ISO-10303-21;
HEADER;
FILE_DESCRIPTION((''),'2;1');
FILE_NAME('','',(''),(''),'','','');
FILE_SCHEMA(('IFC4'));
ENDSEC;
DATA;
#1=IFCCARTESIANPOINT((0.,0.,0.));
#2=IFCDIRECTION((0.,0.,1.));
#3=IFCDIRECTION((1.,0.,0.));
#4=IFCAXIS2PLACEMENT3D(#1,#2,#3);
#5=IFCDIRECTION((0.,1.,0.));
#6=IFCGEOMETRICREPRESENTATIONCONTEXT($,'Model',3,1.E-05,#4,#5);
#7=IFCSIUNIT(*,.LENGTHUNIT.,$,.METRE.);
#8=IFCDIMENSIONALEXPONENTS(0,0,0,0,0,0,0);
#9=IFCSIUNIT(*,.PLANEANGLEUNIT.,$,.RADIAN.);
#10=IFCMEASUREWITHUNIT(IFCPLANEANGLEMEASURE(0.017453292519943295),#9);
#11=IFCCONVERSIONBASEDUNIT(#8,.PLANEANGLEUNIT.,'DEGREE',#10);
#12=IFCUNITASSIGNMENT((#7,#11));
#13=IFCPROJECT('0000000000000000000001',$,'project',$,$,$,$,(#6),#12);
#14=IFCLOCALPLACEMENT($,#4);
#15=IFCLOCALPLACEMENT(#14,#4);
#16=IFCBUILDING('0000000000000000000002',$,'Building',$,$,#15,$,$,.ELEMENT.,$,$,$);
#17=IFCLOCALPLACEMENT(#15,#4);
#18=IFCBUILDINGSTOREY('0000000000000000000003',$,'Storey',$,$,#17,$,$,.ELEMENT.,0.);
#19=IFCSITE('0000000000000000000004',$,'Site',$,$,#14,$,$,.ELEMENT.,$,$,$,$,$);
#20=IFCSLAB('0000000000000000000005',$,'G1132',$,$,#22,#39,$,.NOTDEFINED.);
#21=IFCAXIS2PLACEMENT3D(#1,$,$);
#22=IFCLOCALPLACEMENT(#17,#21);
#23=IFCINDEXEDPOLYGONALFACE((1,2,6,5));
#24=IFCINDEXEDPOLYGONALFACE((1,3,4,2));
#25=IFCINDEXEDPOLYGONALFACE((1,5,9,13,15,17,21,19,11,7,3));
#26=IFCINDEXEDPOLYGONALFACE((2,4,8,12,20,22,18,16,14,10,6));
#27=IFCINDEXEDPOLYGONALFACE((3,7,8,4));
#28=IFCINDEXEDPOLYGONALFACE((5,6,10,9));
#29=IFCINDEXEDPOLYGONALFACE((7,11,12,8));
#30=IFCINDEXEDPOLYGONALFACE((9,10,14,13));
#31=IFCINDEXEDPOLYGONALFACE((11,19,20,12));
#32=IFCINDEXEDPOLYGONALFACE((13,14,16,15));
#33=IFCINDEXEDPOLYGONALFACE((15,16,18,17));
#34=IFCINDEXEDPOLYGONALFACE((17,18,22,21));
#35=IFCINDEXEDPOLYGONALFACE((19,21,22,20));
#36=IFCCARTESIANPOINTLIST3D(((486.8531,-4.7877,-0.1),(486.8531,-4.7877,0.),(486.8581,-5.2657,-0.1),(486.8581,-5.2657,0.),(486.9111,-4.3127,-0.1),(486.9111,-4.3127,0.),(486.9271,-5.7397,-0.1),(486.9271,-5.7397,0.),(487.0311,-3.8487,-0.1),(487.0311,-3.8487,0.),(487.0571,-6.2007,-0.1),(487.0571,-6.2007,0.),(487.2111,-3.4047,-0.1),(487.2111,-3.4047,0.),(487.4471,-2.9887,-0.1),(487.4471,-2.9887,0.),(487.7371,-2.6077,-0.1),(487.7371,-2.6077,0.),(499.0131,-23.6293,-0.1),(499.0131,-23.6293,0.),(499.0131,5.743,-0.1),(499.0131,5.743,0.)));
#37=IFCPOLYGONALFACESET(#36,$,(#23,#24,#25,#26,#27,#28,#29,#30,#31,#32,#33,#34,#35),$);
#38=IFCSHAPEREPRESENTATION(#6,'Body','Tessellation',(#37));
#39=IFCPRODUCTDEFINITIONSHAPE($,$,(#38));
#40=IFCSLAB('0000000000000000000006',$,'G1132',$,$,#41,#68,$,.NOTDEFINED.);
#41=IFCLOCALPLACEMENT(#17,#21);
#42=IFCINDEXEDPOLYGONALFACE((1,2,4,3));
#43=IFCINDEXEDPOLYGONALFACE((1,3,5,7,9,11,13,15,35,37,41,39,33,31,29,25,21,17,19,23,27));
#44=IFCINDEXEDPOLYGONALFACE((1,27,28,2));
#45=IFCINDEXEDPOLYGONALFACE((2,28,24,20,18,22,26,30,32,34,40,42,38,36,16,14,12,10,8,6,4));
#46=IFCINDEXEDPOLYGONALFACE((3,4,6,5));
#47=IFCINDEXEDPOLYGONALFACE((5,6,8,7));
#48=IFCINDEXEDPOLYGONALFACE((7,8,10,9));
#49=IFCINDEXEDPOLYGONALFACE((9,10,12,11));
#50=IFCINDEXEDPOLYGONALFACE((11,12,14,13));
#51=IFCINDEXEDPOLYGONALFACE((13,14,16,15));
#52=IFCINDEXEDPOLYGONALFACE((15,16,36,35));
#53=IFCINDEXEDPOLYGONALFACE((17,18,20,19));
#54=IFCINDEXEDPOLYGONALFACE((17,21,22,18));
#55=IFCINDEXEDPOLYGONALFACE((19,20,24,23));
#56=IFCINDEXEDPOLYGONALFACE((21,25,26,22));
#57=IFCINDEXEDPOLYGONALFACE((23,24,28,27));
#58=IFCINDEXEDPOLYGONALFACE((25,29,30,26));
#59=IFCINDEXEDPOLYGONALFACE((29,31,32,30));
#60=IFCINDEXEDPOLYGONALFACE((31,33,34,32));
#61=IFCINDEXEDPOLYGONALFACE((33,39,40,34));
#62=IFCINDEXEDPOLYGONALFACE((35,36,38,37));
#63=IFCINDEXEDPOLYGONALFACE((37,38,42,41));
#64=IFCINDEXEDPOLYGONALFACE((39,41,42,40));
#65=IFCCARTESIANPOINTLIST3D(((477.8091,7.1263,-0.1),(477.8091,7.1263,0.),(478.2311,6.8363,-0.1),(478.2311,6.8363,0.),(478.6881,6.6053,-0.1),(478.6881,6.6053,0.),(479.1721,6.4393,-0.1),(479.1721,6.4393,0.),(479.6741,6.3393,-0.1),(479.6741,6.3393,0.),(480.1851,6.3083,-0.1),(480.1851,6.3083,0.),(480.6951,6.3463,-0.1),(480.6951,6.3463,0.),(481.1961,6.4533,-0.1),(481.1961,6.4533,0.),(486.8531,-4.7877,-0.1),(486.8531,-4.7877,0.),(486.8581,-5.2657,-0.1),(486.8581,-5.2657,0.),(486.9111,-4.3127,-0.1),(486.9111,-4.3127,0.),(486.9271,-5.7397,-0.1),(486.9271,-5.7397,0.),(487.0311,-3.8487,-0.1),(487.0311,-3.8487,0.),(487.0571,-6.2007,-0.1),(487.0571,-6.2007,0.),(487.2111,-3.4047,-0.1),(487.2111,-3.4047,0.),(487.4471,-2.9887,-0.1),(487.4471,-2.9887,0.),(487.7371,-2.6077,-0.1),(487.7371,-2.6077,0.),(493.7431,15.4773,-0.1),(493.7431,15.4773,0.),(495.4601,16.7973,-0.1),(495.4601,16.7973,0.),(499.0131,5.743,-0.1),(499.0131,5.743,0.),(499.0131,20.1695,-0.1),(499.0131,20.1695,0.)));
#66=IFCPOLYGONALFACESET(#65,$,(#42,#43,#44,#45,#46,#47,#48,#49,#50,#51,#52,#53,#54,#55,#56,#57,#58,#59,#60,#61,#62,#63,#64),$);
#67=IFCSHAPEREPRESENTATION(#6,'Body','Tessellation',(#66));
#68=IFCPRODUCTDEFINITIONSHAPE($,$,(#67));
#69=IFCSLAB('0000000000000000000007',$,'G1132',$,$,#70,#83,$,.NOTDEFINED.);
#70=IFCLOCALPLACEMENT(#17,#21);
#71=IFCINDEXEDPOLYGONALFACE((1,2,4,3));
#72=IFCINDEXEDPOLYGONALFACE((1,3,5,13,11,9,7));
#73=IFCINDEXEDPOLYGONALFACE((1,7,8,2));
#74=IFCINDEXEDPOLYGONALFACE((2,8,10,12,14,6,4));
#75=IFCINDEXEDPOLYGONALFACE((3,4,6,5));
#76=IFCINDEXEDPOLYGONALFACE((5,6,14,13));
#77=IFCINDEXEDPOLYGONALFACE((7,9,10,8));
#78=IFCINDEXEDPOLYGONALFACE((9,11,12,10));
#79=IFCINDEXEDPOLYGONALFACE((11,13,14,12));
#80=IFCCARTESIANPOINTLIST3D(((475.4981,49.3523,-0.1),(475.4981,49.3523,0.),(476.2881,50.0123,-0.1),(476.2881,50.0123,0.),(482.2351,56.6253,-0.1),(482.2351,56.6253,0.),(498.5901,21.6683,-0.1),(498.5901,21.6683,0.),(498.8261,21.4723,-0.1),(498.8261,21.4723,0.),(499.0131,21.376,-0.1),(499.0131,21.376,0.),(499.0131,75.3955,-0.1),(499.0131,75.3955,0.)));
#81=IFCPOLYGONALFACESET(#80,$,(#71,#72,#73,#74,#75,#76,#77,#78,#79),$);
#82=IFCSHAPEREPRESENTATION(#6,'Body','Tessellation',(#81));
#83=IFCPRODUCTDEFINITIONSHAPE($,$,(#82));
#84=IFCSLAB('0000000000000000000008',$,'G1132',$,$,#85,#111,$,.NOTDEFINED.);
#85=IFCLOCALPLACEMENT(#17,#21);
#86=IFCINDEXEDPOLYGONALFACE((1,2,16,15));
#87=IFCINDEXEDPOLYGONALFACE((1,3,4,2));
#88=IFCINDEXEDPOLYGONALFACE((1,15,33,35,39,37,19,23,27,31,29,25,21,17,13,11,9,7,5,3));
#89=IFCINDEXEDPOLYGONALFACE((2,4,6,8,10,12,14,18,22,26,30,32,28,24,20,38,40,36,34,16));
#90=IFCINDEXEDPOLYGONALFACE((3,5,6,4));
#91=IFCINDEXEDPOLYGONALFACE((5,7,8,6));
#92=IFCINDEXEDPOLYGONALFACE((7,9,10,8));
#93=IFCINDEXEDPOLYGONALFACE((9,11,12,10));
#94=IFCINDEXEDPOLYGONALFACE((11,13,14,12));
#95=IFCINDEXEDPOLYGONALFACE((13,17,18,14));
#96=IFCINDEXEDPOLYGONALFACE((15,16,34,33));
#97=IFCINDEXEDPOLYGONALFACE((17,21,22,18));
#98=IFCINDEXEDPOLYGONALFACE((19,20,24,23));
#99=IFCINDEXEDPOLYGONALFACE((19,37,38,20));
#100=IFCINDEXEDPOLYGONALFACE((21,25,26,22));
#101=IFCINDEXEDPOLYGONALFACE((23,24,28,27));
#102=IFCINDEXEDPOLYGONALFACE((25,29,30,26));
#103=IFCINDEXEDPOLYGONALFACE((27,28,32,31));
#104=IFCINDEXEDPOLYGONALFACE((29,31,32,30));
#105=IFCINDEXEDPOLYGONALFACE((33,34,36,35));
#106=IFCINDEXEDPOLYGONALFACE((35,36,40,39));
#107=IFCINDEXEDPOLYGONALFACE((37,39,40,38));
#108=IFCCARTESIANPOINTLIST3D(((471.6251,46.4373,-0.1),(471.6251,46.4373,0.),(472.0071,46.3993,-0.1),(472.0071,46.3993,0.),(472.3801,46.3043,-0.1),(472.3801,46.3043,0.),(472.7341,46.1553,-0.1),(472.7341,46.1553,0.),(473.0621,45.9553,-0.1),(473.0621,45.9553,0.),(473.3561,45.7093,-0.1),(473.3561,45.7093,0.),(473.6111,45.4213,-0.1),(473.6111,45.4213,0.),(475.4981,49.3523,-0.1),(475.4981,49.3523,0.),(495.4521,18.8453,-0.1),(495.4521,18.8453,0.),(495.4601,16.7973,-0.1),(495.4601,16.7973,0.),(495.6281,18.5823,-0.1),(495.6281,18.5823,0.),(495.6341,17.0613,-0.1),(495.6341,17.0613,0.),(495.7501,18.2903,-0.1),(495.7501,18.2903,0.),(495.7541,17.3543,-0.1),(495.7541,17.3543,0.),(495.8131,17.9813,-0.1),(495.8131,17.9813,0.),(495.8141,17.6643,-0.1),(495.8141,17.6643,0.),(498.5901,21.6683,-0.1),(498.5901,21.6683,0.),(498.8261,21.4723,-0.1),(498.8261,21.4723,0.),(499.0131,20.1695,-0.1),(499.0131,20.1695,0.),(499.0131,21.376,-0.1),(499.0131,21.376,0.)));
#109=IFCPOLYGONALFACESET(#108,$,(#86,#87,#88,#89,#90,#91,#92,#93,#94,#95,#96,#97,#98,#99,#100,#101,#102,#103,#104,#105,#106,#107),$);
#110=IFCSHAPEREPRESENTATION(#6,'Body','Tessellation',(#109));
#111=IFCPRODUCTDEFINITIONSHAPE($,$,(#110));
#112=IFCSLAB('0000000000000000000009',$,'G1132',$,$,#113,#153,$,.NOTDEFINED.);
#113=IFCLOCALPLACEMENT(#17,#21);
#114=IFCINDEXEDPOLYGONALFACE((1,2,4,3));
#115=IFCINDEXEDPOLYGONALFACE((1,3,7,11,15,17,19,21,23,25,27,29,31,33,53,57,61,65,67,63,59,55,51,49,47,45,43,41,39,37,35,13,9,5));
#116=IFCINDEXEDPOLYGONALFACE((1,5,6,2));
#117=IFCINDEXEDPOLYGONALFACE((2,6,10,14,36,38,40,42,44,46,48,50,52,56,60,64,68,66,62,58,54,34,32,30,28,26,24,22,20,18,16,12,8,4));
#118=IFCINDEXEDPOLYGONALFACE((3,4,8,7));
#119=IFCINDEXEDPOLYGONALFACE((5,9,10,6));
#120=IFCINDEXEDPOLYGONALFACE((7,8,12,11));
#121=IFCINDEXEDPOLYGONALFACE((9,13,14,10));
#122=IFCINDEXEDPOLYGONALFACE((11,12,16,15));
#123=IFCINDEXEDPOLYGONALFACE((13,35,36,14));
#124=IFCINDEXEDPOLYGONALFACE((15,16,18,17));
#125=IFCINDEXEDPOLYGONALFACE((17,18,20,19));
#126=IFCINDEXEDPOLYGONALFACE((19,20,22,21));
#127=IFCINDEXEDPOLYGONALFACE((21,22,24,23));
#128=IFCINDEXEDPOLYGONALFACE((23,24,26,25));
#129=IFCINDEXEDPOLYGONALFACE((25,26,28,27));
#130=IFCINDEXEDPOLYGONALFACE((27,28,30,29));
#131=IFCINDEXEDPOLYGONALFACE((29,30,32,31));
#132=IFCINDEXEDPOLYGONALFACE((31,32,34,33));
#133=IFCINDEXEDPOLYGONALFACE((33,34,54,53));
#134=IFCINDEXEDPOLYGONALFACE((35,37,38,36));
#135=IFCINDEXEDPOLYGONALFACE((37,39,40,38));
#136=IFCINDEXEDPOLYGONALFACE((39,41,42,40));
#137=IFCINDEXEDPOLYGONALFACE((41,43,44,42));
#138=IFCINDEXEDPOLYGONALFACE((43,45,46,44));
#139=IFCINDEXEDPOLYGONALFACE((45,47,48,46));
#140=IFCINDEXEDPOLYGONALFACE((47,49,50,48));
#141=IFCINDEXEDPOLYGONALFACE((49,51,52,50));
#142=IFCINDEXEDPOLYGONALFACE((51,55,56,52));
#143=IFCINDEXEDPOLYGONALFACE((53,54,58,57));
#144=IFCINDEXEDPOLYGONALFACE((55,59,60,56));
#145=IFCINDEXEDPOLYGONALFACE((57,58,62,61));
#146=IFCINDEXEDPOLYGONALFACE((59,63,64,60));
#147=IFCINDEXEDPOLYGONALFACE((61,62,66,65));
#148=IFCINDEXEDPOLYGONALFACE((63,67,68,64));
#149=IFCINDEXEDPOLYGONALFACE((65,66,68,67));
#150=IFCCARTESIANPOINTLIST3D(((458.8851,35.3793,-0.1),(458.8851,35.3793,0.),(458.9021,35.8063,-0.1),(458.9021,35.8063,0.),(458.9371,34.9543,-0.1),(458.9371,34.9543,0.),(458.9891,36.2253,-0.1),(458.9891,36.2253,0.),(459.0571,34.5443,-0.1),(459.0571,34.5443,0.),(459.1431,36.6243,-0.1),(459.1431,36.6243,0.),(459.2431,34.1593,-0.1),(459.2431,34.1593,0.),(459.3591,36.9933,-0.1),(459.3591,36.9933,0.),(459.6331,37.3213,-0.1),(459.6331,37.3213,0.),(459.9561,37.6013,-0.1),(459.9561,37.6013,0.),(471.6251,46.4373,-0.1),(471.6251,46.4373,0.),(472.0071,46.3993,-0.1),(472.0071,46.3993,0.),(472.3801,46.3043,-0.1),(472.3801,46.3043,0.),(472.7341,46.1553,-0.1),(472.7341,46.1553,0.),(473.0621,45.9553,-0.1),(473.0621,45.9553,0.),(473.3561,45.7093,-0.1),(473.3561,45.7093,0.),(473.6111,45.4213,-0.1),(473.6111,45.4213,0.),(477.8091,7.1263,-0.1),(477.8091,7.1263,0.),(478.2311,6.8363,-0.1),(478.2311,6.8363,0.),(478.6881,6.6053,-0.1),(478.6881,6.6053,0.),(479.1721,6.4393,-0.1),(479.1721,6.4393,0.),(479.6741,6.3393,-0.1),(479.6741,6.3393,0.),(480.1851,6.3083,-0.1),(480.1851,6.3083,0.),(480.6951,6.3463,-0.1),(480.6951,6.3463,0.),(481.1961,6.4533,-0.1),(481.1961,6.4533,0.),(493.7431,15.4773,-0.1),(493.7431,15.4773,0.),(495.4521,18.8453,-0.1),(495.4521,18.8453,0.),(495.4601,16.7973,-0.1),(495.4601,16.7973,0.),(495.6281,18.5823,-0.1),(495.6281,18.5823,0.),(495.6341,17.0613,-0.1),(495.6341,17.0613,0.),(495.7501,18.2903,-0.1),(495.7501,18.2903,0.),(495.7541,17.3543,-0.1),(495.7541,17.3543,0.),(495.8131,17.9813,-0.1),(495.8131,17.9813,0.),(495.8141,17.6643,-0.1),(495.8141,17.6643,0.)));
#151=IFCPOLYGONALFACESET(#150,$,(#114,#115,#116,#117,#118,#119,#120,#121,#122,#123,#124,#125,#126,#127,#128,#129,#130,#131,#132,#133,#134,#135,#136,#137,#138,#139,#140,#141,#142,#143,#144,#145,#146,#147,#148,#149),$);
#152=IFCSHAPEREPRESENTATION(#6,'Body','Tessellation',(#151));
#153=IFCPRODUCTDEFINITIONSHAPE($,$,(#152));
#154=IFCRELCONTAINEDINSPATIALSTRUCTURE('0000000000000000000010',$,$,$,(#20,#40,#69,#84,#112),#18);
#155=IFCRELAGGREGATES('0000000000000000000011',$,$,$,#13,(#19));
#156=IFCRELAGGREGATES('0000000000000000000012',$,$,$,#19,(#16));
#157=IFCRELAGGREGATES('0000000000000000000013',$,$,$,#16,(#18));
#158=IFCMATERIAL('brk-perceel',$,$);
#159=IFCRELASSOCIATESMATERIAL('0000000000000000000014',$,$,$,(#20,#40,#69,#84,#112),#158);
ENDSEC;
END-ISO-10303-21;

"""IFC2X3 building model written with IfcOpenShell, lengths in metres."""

from ifc_helpers import new_model, entity, si_unit, converted_unit, direction, frame, origin_with_axes, place, context, project, spatial, polyline, outline, extrude, material, element, save


model = new_model("IFC2X3")

# Units and contexts
model_context = context("Model", 3, precision=1e-05, world=origin_with_axes(), true_north=direction((0.0, 1.0, 0.0)))
ifc_project = project(units=[si_unit("LENGTHUNIT", "METRE"), converted_unit("PLANEANGLEUNIT", "DEGREE", entity("IfcPlaneAngleMeasure", 0.017453292519943295), si_unit("PLANEANGLEUNIT", "RADIAN"), dimensions=[0, 0, 0, 0, 0, 0, 0])], contexts=[model_context])

# Site, building, storey
site_placement = place(None, origin_with_axes())
site = spatial("IfcSite", under=ifc_project, at=site_placement, Name="Site", CompositionType="ELEMENT")
building_placement = place(site_placement, origin_with_axes())
building = spatial("IfcBuilding", under=site, at=building_placement, Name="Building", CompositionType="ELEMENT")
storey_placement = place(building_placement, origin_with_axes())
storey = spatial("IfcBuildingStorey", under=building, at=storey_placement, Name="Storey", CompositionType="ELEMENT", Elevation=0.0)

# Slabs
ifc_material = material(Name="brk-perceel")
slab_1_placement = place(storey_placement, frame((0.0, 0.0, -0.1), z_axis=(0.0, 0.0, 1.0), x_axis=(1.0, 0.0, 0.0)))
element("IfcSlab", 1, at=slab_1_placement, inside=storey, material=ifc_material, Name="G1132", PredefinedType="NOTDEFINED", context=model_context, shape_type="SweptSolid", body=[
    extrude(outline(polyline([(487.0571, -6.2007), (486.9271, -5.7397), (486.8581, -5.2657), (486.8531, -4.7877), (486.9111, -4.3127), (487.0311, -3.8487), (487.2111, -3.4047), (487.4471, -2.9887), (487.7371, -2.6077), (499.0131, 5.743), (499.0131, -23.6293), (487.0571, -6.2007)])), origin_with_axes(), (0.0, 0.0, 1.0), 0.1),
])
slab_2_placement = place(storey_placement, frame((0.0, 0.0, -0.1), z_axis=(0.0, 0.0, 1.0), x_axis=(1.0, 0.0, 0.0)))
element("IfcSlab", 2, at=slab_2_placement, inside=storey, material=ifc_material, Name="G1132", PredefinedType="NOTDEFINED", context=model_context, shape_type="SweptSolid", body=[
    extrude(outline(polyline([(487.7371, -2.6077), (487.4471, -2.9887), (487.2111, -3.4047), (487.0311, -3.8487), (486.9111, -4.3127), (486.8531, -4.7877), (486.8581, -5.2657), (486.9271, -5.7397), (487.0571, -6.2007), (477.8091, 7.1263), (478.2311, 6.8363), (478.6881, 6.6053), (479.1721, 6.4393), (479.6741, 6.3393), (480.1851, 6.3083), (480.6951, 6.3463), (481.1961, 6.4533), (493.7431, 15.4773), (495.4601, 16.7973), (499.0131, 20.1695), (499.0131, 5.743), (487.7371, -2.6077)])), origin_with_axes(), (0.0, 0.0, 1.0), 0.1),
])
slab_3_placement = place(storey_placement, frame((0.0, 0.0, -0.1), z_axis=(0.0, 0.0, 1.0), x_axis=(1.0, 0.0, 0.0)))
element("IfcSlab", 3, at=slab_3_placement, inside=storey, material=ifc_material, Name="G1132", PredefinedType="NOTDEFINED", context=model_context, shape_type="SweptSolid", body=[
    extrude(outline(polyline([(498.8261, 21.4723), (498.5901, 21.6683), (475.4981, 49.3523), (476.2881, 50.0123), (482.2351, 56.6253), (499.0131, 75.3955), (499.0131, 21.376), (498.8261, 21.4723)])), origin_with_axes(), (0.0, 0.0, 1.0), 0.1),
])
slab_4_placement = place(storey_placement, frame((0.0, 0.0, -0.1), z_axis=(0.0, 0.0, 1.0), x_axis=(1.0, 0.0, 0.0)))
element("IfcSlab", 4, at=slab_4_placement, inside=storey, material=ifc_material, Name="G1132", PredefinedType="NOTDEFINED", context=model_context, shape_type="SweptSolid", body=[
    extrude(outline(polyline([(495.4601, 16.7973), (495.6341, 17.0613), (495.7541, 17.3543), (495.8141, 17.6643), (495.8131, 17.9813), (495.7501, 18.2903), (495.6281, 18.5823), (495.4521, 18.8453), (473.6111, 45.4213), (473.3561, 45.7093), (473.0621, 45.9553), (472.7341, 46.1553), (472.3801, 46.3043), (472.0071, 46.3993), (471.6251, 46.4373), (475.4981, 49.3523), (498.5901, 21.6683), (498.8261, 21.4723), (499.0131, 21.376), (499.0131, 20.1695), (495.4601, 16.7973)])), origin_with_axes(), (0.0, 0.0, 1.0), 0.1),
])
slab_5_placement = place(storey_placement, frame((0.0, 0.0, -0.1), z_axis=(0.0, 0.0, 1.0), x_axis=(1.0, 0.0, 0.0)))
element("IfcSlab", 5, at=slab_5_placement, inside=storey, material=ifc_material, Name="G1132", PredefinedType="NOTDEFINED", context=model_context, shape_type="SweptSolid", body=[
    extrude(outline(polyline([(480.6951, 6.3463), (480.1851, 6.3083), (479.6741, 6.3393), (479.1721, 6.4393), (478.6881, 6.6053), (478.2311, 6.8363), (477.8091, 7.1263), (459.2431, 34.1593), (459.0571, 34.5443), (458.9371, 34.9543), (458.8851, 35.3793), (458.9021, 35.8063), (458.9891, 36.2253), (459.1431, 36.6243), (459.3591, 36.9933), (459.6331, 37.3213), (459.9561, 37.6013), (471.6251, 46.4373), (472.0071, 46.3993), (472.3801, 46.3043), (472.7341, 46.1553), (473.0621, 45.9553), (473.3561, 45.7093), (473.6111, 45.4213), (495.4521, 18.8453), (495.6281, 18.5823), (495.7501, 18.2903), (495.8131, 17.9813), (495.8141, 17.6643), (495.7541, 17.3543), (495.6341, 17.0613), (495.4601, 16.7973), (493.7431, 15.4773), (481.1961, 6.4533), (480.6951, 6.3463)])), origin_with_axes(), (0.0, 0.0, 1.0), 0.1),
])

save(model, "model.ifc")
